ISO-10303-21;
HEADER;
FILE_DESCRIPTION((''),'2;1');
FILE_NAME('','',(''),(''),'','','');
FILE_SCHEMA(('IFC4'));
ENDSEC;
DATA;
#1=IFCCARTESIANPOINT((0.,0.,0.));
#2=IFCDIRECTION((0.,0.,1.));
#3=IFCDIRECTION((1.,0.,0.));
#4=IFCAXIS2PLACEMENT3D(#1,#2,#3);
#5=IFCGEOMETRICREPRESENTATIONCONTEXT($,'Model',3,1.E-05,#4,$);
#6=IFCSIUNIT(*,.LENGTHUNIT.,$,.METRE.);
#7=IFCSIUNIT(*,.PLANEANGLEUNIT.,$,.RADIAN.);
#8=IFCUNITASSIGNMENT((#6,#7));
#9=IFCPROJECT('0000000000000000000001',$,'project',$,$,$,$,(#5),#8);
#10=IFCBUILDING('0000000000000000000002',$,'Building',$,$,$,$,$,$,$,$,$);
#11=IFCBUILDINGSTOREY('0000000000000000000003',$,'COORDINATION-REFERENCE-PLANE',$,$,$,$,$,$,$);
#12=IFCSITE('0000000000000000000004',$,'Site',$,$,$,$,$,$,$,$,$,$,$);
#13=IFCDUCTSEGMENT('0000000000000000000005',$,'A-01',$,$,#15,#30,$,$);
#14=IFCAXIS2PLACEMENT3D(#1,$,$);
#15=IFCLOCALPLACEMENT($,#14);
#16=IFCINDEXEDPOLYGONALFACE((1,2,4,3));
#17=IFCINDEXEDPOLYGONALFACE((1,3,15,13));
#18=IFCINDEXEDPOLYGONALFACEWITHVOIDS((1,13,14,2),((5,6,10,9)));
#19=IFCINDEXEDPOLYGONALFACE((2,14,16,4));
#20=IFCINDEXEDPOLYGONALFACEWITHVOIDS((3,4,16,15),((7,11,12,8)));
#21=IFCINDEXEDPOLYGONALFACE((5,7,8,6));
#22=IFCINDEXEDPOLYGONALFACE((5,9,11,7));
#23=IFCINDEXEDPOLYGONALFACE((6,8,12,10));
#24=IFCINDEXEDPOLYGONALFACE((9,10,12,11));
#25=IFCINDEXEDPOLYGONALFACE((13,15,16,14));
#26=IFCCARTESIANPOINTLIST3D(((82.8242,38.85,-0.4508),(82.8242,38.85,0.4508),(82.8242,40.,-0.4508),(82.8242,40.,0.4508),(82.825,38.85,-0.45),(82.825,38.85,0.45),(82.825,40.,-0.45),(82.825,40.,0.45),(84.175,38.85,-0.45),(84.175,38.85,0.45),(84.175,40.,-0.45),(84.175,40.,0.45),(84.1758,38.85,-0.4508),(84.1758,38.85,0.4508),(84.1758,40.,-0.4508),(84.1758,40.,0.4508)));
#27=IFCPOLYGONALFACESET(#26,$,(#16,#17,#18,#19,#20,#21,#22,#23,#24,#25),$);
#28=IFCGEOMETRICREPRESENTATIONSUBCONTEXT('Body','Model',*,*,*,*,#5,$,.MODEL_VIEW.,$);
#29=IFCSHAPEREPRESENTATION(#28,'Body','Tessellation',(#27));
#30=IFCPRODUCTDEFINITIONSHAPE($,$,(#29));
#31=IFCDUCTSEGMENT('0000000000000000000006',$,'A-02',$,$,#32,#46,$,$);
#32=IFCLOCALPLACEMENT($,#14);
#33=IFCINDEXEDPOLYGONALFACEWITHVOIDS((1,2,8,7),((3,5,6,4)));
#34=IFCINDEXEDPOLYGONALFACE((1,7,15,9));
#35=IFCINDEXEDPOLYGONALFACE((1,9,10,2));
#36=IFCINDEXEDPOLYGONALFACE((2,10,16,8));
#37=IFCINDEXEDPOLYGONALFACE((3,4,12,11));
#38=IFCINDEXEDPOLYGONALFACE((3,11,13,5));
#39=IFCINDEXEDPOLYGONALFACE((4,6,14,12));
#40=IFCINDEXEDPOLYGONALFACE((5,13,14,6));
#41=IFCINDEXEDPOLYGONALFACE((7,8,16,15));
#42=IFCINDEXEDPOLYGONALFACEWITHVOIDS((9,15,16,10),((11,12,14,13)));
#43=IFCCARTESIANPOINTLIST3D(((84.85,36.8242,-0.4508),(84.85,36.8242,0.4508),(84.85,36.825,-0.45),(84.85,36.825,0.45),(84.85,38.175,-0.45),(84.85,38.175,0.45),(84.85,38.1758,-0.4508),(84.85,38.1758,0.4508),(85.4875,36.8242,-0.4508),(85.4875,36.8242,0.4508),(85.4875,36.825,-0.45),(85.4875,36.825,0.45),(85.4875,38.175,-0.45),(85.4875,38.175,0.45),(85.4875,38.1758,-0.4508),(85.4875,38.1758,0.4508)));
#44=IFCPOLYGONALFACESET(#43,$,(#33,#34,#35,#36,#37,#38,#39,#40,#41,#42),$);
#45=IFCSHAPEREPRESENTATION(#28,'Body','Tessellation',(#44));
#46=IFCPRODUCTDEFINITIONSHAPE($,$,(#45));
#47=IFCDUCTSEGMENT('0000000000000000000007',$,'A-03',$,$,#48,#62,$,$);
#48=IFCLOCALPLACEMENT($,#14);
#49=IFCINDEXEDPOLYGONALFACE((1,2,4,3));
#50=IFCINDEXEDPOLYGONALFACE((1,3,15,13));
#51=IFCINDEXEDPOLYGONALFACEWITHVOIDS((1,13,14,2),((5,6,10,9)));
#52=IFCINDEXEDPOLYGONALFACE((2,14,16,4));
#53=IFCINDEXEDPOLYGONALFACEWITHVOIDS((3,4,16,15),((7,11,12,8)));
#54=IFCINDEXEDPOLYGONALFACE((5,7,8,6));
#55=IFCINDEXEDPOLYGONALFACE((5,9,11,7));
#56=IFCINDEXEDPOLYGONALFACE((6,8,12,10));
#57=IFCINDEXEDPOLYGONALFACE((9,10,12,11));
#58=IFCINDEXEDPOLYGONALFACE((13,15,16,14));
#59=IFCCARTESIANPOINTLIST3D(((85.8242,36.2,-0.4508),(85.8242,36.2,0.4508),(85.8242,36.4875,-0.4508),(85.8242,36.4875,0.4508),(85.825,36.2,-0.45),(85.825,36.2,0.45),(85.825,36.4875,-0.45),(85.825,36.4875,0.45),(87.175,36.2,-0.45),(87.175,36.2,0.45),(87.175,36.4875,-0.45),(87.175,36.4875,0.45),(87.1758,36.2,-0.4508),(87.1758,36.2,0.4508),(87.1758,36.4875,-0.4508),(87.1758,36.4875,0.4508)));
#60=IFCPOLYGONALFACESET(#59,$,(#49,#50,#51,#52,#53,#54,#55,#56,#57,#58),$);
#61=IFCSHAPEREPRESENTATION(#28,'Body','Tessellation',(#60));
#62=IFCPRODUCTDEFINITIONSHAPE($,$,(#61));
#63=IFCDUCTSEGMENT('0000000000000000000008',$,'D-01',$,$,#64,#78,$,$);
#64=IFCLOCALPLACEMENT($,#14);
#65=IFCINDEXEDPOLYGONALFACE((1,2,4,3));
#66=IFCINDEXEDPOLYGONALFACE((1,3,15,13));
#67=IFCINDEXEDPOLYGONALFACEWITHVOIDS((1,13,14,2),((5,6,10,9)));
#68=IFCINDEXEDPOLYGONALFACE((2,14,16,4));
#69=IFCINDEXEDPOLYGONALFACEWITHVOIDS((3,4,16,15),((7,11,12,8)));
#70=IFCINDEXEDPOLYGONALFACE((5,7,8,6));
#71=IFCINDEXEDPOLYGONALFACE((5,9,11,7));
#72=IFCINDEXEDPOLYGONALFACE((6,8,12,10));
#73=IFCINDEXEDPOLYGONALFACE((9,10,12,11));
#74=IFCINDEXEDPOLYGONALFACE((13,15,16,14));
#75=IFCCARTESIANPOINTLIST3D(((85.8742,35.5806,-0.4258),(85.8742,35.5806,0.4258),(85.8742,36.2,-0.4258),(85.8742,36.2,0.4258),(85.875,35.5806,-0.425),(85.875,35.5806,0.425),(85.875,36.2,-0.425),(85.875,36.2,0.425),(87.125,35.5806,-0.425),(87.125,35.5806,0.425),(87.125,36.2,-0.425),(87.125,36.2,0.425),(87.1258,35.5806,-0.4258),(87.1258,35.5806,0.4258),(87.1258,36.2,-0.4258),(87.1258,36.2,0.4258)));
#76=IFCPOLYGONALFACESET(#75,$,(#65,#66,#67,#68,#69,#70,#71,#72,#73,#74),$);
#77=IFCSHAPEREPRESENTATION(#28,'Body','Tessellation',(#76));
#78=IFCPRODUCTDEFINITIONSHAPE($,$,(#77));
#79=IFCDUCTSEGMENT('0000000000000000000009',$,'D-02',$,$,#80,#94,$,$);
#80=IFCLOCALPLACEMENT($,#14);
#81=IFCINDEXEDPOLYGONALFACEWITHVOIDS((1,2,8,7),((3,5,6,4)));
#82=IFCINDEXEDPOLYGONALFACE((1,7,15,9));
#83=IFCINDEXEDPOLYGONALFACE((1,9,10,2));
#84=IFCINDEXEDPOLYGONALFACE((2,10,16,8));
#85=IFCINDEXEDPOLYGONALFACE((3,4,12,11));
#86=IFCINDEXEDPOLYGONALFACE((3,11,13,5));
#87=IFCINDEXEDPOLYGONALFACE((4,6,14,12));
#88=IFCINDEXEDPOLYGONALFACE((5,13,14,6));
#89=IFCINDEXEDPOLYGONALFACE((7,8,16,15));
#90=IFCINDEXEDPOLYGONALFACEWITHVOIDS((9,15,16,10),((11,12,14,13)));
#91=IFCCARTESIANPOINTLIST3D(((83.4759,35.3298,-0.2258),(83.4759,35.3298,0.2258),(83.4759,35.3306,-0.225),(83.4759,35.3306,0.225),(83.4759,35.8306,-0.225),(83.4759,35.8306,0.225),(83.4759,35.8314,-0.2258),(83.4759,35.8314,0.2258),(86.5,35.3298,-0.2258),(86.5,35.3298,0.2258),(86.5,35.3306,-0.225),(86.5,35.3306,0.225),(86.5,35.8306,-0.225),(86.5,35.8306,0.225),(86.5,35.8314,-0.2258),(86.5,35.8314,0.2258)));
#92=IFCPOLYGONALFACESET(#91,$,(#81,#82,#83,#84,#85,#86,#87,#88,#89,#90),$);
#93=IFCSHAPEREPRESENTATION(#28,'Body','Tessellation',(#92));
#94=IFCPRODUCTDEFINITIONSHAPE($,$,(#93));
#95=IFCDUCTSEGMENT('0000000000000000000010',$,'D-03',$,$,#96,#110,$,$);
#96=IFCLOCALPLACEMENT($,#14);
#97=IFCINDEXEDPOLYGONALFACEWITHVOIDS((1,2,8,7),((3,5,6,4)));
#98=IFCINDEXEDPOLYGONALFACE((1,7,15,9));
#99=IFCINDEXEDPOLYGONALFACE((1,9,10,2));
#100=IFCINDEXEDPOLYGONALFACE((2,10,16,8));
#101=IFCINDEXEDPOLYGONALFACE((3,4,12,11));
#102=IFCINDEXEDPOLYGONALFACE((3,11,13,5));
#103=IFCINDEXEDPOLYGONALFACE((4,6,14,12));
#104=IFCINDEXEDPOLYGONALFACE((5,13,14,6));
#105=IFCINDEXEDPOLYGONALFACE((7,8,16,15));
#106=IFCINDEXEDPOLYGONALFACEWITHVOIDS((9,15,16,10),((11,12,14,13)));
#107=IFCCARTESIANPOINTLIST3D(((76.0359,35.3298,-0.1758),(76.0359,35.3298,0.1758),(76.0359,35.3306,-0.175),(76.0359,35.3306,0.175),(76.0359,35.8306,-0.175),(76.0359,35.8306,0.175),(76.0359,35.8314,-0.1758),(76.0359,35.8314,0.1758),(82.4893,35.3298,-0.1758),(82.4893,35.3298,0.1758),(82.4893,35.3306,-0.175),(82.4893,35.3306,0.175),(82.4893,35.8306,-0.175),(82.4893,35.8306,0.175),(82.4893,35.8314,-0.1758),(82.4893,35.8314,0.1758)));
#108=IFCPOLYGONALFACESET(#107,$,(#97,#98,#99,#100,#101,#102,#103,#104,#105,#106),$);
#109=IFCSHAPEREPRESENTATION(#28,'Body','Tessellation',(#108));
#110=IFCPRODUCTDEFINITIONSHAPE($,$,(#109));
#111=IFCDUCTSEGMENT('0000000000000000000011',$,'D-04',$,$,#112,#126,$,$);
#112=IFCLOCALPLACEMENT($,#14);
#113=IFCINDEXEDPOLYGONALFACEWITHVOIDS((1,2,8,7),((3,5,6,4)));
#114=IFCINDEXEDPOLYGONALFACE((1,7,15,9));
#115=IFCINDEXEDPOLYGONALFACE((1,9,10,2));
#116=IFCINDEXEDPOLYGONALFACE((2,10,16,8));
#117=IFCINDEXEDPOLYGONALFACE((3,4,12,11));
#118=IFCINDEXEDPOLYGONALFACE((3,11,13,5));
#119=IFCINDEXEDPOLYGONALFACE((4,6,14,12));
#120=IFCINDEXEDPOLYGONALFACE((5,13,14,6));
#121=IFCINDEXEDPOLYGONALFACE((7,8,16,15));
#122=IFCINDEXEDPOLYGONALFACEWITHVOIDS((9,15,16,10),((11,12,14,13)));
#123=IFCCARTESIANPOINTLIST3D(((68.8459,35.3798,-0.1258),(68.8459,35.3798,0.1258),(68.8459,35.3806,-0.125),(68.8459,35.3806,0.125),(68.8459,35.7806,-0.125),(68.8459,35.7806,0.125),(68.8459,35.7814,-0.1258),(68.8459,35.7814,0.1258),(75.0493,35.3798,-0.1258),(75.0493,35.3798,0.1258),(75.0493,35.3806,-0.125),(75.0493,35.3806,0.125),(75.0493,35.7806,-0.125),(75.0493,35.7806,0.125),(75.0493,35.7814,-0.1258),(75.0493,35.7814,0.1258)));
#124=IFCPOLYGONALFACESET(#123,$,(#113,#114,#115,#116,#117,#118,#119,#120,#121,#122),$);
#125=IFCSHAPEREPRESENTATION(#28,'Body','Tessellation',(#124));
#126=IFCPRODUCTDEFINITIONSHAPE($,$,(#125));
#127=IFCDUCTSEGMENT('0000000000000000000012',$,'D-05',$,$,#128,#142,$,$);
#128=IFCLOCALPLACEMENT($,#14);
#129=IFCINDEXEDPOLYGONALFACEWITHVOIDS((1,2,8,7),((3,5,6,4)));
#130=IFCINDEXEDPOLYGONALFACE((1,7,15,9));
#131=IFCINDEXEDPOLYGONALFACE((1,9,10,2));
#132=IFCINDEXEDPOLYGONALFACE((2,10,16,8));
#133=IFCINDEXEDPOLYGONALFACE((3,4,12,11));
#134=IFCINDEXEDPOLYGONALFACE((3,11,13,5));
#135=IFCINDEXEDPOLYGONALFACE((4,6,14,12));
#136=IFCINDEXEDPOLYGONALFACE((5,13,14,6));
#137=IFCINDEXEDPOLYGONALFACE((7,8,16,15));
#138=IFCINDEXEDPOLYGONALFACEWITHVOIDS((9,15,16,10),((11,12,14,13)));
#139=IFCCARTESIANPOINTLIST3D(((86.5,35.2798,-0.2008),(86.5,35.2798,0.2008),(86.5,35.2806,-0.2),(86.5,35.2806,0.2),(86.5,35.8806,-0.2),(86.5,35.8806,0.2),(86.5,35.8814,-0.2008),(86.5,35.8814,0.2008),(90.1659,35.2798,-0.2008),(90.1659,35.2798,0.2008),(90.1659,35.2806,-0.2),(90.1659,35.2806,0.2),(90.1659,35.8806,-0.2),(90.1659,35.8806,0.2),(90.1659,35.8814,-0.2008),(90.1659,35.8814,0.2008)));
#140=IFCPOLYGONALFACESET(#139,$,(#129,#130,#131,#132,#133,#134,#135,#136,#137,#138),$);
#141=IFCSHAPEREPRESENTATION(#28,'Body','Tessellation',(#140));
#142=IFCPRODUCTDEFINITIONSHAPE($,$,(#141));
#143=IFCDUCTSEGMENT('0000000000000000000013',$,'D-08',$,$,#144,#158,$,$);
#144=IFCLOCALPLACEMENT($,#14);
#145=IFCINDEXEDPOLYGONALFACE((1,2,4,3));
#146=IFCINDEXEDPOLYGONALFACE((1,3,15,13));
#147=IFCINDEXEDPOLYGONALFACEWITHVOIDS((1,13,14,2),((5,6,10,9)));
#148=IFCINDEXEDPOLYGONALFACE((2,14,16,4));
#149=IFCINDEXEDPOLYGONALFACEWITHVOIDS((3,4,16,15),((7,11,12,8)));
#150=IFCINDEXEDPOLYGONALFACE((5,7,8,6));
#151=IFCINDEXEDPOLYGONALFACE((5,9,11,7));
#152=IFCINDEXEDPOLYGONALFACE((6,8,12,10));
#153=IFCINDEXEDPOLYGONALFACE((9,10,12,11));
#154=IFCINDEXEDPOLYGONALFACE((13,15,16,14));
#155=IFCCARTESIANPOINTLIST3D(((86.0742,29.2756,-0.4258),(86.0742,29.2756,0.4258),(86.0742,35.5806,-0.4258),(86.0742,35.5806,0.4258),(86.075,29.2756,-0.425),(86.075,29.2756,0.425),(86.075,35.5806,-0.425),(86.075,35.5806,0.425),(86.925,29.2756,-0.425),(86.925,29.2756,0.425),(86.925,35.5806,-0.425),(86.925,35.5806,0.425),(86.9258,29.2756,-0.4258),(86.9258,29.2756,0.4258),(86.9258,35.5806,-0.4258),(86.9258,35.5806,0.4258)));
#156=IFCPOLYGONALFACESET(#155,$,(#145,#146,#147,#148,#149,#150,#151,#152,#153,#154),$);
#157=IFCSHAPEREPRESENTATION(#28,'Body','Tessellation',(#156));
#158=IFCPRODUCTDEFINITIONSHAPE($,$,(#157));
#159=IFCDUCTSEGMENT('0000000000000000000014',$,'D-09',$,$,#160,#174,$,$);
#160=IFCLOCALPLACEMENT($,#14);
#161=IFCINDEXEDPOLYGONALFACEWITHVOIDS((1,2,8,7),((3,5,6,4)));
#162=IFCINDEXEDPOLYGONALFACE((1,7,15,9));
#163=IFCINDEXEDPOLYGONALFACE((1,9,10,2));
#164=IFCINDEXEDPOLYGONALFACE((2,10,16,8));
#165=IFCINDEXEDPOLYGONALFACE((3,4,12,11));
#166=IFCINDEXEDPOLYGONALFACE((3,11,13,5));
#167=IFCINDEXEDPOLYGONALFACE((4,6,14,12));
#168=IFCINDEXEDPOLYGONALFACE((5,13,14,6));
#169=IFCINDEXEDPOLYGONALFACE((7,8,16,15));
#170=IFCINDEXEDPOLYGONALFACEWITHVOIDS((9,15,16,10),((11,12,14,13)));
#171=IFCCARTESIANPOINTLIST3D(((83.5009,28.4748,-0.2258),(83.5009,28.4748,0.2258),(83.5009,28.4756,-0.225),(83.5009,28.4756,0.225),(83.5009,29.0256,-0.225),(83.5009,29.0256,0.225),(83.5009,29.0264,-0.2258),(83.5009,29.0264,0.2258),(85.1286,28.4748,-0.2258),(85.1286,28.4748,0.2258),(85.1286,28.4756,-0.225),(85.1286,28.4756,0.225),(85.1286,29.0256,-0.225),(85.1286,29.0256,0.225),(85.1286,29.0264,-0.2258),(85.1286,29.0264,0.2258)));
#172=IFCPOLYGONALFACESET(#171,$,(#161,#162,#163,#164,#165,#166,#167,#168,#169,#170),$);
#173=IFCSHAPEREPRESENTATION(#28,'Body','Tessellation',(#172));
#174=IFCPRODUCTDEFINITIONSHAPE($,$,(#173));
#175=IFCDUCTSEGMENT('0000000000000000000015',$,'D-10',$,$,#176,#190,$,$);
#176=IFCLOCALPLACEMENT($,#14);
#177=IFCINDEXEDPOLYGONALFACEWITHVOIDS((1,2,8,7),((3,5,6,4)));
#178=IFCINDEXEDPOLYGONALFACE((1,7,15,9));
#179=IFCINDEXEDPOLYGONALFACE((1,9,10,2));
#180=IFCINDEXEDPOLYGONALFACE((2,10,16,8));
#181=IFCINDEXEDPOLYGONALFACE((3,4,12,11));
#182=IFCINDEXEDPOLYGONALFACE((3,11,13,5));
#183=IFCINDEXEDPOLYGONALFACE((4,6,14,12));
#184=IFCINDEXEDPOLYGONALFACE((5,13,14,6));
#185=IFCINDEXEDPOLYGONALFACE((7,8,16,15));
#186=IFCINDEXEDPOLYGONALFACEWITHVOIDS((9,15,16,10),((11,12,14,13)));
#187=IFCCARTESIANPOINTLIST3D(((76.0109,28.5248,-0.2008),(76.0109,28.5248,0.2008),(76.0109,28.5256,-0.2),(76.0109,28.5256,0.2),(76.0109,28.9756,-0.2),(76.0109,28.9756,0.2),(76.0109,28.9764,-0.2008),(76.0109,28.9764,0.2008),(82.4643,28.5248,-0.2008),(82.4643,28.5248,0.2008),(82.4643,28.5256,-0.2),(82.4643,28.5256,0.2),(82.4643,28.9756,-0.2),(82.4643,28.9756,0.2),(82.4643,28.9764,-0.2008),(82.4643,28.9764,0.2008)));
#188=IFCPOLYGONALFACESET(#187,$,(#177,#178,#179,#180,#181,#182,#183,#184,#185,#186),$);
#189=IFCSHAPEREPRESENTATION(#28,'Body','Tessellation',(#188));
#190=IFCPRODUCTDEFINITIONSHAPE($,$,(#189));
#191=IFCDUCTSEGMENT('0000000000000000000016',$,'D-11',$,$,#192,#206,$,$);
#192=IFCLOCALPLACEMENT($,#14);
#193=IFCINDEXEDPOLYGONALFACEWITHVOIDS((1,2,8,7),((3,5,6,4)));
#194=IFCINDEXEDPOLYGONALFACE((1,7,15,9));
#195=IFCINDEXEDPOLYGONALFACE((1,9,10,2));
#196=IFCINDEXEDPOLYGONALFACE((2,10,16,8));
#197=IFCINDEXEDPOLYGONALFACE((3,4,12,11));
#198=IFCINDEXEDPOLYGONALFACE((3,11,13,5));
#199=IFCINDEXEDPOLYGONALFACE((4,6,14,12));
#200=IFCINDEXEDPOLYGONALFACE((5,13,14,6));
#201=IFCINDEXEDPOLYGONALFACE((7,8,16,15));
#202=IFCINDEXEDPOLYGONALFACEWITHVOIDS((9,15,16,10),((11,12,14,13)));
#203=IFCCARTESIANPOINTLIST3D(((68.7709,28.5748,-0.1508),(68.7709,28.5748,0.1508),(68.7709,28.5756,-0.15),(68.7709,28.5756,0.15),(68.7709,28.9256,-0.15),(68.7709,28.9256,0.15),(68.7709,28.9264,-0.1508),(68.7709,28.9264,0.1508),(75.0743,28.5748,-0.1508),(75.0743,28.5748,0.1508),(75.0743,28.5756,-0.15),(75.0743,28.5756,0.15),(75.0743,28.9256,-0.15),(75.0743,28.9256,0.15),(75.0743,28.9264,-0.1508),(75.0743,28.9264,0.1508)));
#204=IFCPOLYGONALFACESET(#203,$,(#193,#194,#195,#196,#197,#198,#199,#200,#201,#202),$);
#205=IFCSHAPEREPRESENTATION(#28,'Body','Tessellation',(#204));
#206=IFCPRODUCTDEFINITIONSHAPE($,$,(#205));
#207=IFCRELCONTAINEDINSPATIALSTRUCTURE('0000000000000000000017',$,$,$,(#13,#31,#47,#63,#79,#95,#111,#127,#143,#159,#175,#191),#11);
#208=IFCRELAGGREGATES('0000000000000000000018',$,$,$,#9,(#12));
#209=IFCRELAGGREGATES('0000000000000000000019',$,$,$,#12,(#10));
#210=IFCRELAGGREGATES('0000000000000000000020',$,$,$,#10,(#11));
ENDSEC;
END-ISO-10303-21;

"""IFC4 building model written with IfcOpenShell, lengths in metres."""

from ifc_helpers import new_model, si_unit, frame, origin, origin_with_axes, place, context, subcontext, project, spatial, hollow_rectangle, extrude, element, save


model = new_model("IFC4")

# Units and contexts
model_context = context("Model", 3, precision=1e-05, world=origin_with_axes())
body_context = subcontext(model_context, "Body", "Model", "MODEL_VIEW")
ifc_project = project(units=[si_unit("LENGTHUNIT", "METRE"), si_unit("PLANEANGLEUNIT", "RADIAN")], contexts=[model_context])

# Site, building, storey
site = spatial("IfcSite", under=ifc_project, Name="Site")
building = spatial("IfcBuilding", under=site, Name="Building")
storey = spatial("IfcBuildingStorey", under=building, Name="COORDINATION-REFERENCE-PLANE")

# Duct segments
duct_segment_1_placement = place(None, frame((83.5, 38.85, 0.0), z_axis=(0.0, 1.0, 0.0), x_axis=(1.0, 0.0, 0.0)))
element("IfcDuctSegment", 1, at=duct_segment_1_placement, inside=storey, Name="A-01", context=body_context, shape_type="SweptSolid", body=[
    extrude(hollow_rectangle(XDim=1.3516, YDim=0.9016, WallThickness=0.0008), origin(), (0.0, 0.0, 1.0), 1.15),
])
duct_segment_2_placement = place(None, frame((84.85, 37.5, 0.0), z_axis=(1.0, 0.0, 0.0), x_axis=(0.0, 1.0, 0.0)))
element("IfcDuctSegment", 2, at=duct_segment_2_placement, inside=storey, Name="A-02", context=body_context, shape_type="SweptSolid", body=[
    extrude(hollow_rectangle(XDim=1.3516, YDim=0.9016, WallThickness=0.0008), origin(), (0.0, 0.0, 1.0), 0.6375),
])
duct_segment_3_placement = place(None, frame((86.5, 36.2, 0.0), z_axis=(0.0, 1.0, 0.0), x_axis=(1.0, 0.0, 0.0)))
element("IfcDuctSegment", 3, at=duct_segment_3_placement, inside=storey, Name="A-03", context=body_context, shape_type="SweptSolid", body=[
    extrude(hollow_rectangle(XDim=1.3516, YDim=0.9016, WallThickness=0.0008), origin(), (0.0, 0.0, 1.0), 0.2875),
])
duct_segment_4_placement = place(None, frame((86.5, 35.5806, 0.0), z_axis=(0.0, 1.0, 0.0), x_axis=(1.0, 0.0, 0.0)))
element("IfcDuctSegment", 4, at=duct_segment_4_placement, inside=storey, Name="D-01", context=body_context, shape_type="SweptSolid", body=[
    extrude(hollow_rectangle(XDim=1.2516, YDim=0.8516, WallThickness=0.0008), origin(), (0.0, 0.0, 1.0), 0.6194),
])
duct_segment_5_placement = place(None, frame((83.4759, 35.5806, 0.0), z_axis=(1.0, 0.0, 0.0), x_axis=(0.0, 1.0, 0.0)))
element("IfcDuctSegment", 5, at=duct_segment_5_placement, inside=storey, Name="D-02", context=body_context, shape_type="SweptSolid", body=[
    extrude(hollow_rectangle(XDim=0.5016, YDim=0.4516, WallThickness=0.0008), origin(), (0.0, 0.0, 1.0), 3.0241),
])
duct_segment_6_placement = place(None, frame((76.0359, 35.5806, 0.0), z_axis=(1.0, 0.0, 0.0), x_axis=(0.0, 1.0, 0.0)))
element("IfcDuctSegment", 6, at=duct_segment_6_placement, inside=storey, Name="D-03", context=body_context, shape_type="SweptSolid", body=[
    extrude(hollow_rectangle(XDim=0.5016, YDim=0.3516, WallThickness=0.0008), origin(), (0.0, 0.0, 1.0), 6.4534),
])
duct_segment_7_placement = place(None, frame((68.8459, 35.5806, 0.0), z_axis=(1.0, 0.0, 0.0), x_axis=(0.0, 1.0, 0.0)))
element("IfcDuctSegment", 7, at=duct_segment_7_placement, inside=storey, Name="D-04", context=body_context, shape_type="SweptSolid", body=[
    extrude(hollow_rectangle(XDim=0.4016, YDim=0.2516, WallThickness=0.0008), origin(), (0.0, 0.0, 1.0), 6.2034),
])
duct_segment_8_placement = place(None, frame((86.5, 35.5806, 0.0), z_axis=(1.0, 0.0, 0.0), x_axis=(0.0, 1.0, 0.0)))
element("IfcDuctSegment", 8, at=duct_segment_8_placement, inside=storey, Name="D-05", context=body_context, shape_type="SweptSolid", body=[
    extrude(hollow_rectangle(XDim=0.6016, YDim=0.4016, WallThickness=0.0008), origin(), (0.0, 0.0, 1.0), 3.6659),
])
duct_segment_9_placement = place(None, frame((86.5, 29.2756, 0.0), z_axis=(0.0, 1.0, 0.0), x_axis=(1.0, 0.0, 0.0)))
element("IfcDuctSegment", 9, at=duct_segment_9_placement, inside=storey, Name="D-08", context=body_context, shape_type="SweptSolid", body=[
    extrude(hollow_rectangle(XDim=0.8516, YDim=0.8516, WallThickness=0.0008), origin(), (0.0, 0.0, 1.0), 6.305),
])
duct_segment_10_placement = place(None, frame((83.5009, 28.7506, 0.0), z_axis=(1.0, 0.0, 0.0), x_axis=(0.0, 1.0, 0.0)))
element("IfcDuctSegment", 10, at=duct_segment_10_placement, inside=storey, Name="D-09", context=body_context, shape_type="SweptSolid", body=[
    extrude(hollow_rectangle(XDim=0.5516, YDim=0.4516, WallThickness=0.0008), origin(), (0.0, 0.0, 1.0), 1.6277),
])
duct_segment_11_placement = place(None, frame((76.0109, 28.7506, 0.0), z_axis=(1.0, 0.0, 0.0), x_axis=(0.0, 1.0, 0.0)))
element("IfcDuctSegment", 11, at=duct_segment_11_placement, inside=storey, Name="D-10", context=body_context, shape_type="SweptSolid", body=[
    extrude(hollow_rectangle(XDim=0.4516, YDim=0.4016, WallThickness=0.0008), origin(), (0.0, 0.0, 1.0), 6.4534),
])
duct_segment_12_placement = place(None, frame((68.7709, 28.7506, 0.0), z_axis=(1.0, 0.0, 0.0), x_axis=(0.0, 1.0, 0.0)))
element("IfcDuctSegment", 12, at=duct_segment_12_placement, inside=storey, Name="D-11", context=body_context, shape_type="SweptSolid", body=[
    extrude(hollow_rectangle(XDim=0.3516, YDim=0.3016, WallThickness=0.0008), origin(), (0.0, 0.0, 1.0), 6.3034),
])

save(model, "model.ifc")
